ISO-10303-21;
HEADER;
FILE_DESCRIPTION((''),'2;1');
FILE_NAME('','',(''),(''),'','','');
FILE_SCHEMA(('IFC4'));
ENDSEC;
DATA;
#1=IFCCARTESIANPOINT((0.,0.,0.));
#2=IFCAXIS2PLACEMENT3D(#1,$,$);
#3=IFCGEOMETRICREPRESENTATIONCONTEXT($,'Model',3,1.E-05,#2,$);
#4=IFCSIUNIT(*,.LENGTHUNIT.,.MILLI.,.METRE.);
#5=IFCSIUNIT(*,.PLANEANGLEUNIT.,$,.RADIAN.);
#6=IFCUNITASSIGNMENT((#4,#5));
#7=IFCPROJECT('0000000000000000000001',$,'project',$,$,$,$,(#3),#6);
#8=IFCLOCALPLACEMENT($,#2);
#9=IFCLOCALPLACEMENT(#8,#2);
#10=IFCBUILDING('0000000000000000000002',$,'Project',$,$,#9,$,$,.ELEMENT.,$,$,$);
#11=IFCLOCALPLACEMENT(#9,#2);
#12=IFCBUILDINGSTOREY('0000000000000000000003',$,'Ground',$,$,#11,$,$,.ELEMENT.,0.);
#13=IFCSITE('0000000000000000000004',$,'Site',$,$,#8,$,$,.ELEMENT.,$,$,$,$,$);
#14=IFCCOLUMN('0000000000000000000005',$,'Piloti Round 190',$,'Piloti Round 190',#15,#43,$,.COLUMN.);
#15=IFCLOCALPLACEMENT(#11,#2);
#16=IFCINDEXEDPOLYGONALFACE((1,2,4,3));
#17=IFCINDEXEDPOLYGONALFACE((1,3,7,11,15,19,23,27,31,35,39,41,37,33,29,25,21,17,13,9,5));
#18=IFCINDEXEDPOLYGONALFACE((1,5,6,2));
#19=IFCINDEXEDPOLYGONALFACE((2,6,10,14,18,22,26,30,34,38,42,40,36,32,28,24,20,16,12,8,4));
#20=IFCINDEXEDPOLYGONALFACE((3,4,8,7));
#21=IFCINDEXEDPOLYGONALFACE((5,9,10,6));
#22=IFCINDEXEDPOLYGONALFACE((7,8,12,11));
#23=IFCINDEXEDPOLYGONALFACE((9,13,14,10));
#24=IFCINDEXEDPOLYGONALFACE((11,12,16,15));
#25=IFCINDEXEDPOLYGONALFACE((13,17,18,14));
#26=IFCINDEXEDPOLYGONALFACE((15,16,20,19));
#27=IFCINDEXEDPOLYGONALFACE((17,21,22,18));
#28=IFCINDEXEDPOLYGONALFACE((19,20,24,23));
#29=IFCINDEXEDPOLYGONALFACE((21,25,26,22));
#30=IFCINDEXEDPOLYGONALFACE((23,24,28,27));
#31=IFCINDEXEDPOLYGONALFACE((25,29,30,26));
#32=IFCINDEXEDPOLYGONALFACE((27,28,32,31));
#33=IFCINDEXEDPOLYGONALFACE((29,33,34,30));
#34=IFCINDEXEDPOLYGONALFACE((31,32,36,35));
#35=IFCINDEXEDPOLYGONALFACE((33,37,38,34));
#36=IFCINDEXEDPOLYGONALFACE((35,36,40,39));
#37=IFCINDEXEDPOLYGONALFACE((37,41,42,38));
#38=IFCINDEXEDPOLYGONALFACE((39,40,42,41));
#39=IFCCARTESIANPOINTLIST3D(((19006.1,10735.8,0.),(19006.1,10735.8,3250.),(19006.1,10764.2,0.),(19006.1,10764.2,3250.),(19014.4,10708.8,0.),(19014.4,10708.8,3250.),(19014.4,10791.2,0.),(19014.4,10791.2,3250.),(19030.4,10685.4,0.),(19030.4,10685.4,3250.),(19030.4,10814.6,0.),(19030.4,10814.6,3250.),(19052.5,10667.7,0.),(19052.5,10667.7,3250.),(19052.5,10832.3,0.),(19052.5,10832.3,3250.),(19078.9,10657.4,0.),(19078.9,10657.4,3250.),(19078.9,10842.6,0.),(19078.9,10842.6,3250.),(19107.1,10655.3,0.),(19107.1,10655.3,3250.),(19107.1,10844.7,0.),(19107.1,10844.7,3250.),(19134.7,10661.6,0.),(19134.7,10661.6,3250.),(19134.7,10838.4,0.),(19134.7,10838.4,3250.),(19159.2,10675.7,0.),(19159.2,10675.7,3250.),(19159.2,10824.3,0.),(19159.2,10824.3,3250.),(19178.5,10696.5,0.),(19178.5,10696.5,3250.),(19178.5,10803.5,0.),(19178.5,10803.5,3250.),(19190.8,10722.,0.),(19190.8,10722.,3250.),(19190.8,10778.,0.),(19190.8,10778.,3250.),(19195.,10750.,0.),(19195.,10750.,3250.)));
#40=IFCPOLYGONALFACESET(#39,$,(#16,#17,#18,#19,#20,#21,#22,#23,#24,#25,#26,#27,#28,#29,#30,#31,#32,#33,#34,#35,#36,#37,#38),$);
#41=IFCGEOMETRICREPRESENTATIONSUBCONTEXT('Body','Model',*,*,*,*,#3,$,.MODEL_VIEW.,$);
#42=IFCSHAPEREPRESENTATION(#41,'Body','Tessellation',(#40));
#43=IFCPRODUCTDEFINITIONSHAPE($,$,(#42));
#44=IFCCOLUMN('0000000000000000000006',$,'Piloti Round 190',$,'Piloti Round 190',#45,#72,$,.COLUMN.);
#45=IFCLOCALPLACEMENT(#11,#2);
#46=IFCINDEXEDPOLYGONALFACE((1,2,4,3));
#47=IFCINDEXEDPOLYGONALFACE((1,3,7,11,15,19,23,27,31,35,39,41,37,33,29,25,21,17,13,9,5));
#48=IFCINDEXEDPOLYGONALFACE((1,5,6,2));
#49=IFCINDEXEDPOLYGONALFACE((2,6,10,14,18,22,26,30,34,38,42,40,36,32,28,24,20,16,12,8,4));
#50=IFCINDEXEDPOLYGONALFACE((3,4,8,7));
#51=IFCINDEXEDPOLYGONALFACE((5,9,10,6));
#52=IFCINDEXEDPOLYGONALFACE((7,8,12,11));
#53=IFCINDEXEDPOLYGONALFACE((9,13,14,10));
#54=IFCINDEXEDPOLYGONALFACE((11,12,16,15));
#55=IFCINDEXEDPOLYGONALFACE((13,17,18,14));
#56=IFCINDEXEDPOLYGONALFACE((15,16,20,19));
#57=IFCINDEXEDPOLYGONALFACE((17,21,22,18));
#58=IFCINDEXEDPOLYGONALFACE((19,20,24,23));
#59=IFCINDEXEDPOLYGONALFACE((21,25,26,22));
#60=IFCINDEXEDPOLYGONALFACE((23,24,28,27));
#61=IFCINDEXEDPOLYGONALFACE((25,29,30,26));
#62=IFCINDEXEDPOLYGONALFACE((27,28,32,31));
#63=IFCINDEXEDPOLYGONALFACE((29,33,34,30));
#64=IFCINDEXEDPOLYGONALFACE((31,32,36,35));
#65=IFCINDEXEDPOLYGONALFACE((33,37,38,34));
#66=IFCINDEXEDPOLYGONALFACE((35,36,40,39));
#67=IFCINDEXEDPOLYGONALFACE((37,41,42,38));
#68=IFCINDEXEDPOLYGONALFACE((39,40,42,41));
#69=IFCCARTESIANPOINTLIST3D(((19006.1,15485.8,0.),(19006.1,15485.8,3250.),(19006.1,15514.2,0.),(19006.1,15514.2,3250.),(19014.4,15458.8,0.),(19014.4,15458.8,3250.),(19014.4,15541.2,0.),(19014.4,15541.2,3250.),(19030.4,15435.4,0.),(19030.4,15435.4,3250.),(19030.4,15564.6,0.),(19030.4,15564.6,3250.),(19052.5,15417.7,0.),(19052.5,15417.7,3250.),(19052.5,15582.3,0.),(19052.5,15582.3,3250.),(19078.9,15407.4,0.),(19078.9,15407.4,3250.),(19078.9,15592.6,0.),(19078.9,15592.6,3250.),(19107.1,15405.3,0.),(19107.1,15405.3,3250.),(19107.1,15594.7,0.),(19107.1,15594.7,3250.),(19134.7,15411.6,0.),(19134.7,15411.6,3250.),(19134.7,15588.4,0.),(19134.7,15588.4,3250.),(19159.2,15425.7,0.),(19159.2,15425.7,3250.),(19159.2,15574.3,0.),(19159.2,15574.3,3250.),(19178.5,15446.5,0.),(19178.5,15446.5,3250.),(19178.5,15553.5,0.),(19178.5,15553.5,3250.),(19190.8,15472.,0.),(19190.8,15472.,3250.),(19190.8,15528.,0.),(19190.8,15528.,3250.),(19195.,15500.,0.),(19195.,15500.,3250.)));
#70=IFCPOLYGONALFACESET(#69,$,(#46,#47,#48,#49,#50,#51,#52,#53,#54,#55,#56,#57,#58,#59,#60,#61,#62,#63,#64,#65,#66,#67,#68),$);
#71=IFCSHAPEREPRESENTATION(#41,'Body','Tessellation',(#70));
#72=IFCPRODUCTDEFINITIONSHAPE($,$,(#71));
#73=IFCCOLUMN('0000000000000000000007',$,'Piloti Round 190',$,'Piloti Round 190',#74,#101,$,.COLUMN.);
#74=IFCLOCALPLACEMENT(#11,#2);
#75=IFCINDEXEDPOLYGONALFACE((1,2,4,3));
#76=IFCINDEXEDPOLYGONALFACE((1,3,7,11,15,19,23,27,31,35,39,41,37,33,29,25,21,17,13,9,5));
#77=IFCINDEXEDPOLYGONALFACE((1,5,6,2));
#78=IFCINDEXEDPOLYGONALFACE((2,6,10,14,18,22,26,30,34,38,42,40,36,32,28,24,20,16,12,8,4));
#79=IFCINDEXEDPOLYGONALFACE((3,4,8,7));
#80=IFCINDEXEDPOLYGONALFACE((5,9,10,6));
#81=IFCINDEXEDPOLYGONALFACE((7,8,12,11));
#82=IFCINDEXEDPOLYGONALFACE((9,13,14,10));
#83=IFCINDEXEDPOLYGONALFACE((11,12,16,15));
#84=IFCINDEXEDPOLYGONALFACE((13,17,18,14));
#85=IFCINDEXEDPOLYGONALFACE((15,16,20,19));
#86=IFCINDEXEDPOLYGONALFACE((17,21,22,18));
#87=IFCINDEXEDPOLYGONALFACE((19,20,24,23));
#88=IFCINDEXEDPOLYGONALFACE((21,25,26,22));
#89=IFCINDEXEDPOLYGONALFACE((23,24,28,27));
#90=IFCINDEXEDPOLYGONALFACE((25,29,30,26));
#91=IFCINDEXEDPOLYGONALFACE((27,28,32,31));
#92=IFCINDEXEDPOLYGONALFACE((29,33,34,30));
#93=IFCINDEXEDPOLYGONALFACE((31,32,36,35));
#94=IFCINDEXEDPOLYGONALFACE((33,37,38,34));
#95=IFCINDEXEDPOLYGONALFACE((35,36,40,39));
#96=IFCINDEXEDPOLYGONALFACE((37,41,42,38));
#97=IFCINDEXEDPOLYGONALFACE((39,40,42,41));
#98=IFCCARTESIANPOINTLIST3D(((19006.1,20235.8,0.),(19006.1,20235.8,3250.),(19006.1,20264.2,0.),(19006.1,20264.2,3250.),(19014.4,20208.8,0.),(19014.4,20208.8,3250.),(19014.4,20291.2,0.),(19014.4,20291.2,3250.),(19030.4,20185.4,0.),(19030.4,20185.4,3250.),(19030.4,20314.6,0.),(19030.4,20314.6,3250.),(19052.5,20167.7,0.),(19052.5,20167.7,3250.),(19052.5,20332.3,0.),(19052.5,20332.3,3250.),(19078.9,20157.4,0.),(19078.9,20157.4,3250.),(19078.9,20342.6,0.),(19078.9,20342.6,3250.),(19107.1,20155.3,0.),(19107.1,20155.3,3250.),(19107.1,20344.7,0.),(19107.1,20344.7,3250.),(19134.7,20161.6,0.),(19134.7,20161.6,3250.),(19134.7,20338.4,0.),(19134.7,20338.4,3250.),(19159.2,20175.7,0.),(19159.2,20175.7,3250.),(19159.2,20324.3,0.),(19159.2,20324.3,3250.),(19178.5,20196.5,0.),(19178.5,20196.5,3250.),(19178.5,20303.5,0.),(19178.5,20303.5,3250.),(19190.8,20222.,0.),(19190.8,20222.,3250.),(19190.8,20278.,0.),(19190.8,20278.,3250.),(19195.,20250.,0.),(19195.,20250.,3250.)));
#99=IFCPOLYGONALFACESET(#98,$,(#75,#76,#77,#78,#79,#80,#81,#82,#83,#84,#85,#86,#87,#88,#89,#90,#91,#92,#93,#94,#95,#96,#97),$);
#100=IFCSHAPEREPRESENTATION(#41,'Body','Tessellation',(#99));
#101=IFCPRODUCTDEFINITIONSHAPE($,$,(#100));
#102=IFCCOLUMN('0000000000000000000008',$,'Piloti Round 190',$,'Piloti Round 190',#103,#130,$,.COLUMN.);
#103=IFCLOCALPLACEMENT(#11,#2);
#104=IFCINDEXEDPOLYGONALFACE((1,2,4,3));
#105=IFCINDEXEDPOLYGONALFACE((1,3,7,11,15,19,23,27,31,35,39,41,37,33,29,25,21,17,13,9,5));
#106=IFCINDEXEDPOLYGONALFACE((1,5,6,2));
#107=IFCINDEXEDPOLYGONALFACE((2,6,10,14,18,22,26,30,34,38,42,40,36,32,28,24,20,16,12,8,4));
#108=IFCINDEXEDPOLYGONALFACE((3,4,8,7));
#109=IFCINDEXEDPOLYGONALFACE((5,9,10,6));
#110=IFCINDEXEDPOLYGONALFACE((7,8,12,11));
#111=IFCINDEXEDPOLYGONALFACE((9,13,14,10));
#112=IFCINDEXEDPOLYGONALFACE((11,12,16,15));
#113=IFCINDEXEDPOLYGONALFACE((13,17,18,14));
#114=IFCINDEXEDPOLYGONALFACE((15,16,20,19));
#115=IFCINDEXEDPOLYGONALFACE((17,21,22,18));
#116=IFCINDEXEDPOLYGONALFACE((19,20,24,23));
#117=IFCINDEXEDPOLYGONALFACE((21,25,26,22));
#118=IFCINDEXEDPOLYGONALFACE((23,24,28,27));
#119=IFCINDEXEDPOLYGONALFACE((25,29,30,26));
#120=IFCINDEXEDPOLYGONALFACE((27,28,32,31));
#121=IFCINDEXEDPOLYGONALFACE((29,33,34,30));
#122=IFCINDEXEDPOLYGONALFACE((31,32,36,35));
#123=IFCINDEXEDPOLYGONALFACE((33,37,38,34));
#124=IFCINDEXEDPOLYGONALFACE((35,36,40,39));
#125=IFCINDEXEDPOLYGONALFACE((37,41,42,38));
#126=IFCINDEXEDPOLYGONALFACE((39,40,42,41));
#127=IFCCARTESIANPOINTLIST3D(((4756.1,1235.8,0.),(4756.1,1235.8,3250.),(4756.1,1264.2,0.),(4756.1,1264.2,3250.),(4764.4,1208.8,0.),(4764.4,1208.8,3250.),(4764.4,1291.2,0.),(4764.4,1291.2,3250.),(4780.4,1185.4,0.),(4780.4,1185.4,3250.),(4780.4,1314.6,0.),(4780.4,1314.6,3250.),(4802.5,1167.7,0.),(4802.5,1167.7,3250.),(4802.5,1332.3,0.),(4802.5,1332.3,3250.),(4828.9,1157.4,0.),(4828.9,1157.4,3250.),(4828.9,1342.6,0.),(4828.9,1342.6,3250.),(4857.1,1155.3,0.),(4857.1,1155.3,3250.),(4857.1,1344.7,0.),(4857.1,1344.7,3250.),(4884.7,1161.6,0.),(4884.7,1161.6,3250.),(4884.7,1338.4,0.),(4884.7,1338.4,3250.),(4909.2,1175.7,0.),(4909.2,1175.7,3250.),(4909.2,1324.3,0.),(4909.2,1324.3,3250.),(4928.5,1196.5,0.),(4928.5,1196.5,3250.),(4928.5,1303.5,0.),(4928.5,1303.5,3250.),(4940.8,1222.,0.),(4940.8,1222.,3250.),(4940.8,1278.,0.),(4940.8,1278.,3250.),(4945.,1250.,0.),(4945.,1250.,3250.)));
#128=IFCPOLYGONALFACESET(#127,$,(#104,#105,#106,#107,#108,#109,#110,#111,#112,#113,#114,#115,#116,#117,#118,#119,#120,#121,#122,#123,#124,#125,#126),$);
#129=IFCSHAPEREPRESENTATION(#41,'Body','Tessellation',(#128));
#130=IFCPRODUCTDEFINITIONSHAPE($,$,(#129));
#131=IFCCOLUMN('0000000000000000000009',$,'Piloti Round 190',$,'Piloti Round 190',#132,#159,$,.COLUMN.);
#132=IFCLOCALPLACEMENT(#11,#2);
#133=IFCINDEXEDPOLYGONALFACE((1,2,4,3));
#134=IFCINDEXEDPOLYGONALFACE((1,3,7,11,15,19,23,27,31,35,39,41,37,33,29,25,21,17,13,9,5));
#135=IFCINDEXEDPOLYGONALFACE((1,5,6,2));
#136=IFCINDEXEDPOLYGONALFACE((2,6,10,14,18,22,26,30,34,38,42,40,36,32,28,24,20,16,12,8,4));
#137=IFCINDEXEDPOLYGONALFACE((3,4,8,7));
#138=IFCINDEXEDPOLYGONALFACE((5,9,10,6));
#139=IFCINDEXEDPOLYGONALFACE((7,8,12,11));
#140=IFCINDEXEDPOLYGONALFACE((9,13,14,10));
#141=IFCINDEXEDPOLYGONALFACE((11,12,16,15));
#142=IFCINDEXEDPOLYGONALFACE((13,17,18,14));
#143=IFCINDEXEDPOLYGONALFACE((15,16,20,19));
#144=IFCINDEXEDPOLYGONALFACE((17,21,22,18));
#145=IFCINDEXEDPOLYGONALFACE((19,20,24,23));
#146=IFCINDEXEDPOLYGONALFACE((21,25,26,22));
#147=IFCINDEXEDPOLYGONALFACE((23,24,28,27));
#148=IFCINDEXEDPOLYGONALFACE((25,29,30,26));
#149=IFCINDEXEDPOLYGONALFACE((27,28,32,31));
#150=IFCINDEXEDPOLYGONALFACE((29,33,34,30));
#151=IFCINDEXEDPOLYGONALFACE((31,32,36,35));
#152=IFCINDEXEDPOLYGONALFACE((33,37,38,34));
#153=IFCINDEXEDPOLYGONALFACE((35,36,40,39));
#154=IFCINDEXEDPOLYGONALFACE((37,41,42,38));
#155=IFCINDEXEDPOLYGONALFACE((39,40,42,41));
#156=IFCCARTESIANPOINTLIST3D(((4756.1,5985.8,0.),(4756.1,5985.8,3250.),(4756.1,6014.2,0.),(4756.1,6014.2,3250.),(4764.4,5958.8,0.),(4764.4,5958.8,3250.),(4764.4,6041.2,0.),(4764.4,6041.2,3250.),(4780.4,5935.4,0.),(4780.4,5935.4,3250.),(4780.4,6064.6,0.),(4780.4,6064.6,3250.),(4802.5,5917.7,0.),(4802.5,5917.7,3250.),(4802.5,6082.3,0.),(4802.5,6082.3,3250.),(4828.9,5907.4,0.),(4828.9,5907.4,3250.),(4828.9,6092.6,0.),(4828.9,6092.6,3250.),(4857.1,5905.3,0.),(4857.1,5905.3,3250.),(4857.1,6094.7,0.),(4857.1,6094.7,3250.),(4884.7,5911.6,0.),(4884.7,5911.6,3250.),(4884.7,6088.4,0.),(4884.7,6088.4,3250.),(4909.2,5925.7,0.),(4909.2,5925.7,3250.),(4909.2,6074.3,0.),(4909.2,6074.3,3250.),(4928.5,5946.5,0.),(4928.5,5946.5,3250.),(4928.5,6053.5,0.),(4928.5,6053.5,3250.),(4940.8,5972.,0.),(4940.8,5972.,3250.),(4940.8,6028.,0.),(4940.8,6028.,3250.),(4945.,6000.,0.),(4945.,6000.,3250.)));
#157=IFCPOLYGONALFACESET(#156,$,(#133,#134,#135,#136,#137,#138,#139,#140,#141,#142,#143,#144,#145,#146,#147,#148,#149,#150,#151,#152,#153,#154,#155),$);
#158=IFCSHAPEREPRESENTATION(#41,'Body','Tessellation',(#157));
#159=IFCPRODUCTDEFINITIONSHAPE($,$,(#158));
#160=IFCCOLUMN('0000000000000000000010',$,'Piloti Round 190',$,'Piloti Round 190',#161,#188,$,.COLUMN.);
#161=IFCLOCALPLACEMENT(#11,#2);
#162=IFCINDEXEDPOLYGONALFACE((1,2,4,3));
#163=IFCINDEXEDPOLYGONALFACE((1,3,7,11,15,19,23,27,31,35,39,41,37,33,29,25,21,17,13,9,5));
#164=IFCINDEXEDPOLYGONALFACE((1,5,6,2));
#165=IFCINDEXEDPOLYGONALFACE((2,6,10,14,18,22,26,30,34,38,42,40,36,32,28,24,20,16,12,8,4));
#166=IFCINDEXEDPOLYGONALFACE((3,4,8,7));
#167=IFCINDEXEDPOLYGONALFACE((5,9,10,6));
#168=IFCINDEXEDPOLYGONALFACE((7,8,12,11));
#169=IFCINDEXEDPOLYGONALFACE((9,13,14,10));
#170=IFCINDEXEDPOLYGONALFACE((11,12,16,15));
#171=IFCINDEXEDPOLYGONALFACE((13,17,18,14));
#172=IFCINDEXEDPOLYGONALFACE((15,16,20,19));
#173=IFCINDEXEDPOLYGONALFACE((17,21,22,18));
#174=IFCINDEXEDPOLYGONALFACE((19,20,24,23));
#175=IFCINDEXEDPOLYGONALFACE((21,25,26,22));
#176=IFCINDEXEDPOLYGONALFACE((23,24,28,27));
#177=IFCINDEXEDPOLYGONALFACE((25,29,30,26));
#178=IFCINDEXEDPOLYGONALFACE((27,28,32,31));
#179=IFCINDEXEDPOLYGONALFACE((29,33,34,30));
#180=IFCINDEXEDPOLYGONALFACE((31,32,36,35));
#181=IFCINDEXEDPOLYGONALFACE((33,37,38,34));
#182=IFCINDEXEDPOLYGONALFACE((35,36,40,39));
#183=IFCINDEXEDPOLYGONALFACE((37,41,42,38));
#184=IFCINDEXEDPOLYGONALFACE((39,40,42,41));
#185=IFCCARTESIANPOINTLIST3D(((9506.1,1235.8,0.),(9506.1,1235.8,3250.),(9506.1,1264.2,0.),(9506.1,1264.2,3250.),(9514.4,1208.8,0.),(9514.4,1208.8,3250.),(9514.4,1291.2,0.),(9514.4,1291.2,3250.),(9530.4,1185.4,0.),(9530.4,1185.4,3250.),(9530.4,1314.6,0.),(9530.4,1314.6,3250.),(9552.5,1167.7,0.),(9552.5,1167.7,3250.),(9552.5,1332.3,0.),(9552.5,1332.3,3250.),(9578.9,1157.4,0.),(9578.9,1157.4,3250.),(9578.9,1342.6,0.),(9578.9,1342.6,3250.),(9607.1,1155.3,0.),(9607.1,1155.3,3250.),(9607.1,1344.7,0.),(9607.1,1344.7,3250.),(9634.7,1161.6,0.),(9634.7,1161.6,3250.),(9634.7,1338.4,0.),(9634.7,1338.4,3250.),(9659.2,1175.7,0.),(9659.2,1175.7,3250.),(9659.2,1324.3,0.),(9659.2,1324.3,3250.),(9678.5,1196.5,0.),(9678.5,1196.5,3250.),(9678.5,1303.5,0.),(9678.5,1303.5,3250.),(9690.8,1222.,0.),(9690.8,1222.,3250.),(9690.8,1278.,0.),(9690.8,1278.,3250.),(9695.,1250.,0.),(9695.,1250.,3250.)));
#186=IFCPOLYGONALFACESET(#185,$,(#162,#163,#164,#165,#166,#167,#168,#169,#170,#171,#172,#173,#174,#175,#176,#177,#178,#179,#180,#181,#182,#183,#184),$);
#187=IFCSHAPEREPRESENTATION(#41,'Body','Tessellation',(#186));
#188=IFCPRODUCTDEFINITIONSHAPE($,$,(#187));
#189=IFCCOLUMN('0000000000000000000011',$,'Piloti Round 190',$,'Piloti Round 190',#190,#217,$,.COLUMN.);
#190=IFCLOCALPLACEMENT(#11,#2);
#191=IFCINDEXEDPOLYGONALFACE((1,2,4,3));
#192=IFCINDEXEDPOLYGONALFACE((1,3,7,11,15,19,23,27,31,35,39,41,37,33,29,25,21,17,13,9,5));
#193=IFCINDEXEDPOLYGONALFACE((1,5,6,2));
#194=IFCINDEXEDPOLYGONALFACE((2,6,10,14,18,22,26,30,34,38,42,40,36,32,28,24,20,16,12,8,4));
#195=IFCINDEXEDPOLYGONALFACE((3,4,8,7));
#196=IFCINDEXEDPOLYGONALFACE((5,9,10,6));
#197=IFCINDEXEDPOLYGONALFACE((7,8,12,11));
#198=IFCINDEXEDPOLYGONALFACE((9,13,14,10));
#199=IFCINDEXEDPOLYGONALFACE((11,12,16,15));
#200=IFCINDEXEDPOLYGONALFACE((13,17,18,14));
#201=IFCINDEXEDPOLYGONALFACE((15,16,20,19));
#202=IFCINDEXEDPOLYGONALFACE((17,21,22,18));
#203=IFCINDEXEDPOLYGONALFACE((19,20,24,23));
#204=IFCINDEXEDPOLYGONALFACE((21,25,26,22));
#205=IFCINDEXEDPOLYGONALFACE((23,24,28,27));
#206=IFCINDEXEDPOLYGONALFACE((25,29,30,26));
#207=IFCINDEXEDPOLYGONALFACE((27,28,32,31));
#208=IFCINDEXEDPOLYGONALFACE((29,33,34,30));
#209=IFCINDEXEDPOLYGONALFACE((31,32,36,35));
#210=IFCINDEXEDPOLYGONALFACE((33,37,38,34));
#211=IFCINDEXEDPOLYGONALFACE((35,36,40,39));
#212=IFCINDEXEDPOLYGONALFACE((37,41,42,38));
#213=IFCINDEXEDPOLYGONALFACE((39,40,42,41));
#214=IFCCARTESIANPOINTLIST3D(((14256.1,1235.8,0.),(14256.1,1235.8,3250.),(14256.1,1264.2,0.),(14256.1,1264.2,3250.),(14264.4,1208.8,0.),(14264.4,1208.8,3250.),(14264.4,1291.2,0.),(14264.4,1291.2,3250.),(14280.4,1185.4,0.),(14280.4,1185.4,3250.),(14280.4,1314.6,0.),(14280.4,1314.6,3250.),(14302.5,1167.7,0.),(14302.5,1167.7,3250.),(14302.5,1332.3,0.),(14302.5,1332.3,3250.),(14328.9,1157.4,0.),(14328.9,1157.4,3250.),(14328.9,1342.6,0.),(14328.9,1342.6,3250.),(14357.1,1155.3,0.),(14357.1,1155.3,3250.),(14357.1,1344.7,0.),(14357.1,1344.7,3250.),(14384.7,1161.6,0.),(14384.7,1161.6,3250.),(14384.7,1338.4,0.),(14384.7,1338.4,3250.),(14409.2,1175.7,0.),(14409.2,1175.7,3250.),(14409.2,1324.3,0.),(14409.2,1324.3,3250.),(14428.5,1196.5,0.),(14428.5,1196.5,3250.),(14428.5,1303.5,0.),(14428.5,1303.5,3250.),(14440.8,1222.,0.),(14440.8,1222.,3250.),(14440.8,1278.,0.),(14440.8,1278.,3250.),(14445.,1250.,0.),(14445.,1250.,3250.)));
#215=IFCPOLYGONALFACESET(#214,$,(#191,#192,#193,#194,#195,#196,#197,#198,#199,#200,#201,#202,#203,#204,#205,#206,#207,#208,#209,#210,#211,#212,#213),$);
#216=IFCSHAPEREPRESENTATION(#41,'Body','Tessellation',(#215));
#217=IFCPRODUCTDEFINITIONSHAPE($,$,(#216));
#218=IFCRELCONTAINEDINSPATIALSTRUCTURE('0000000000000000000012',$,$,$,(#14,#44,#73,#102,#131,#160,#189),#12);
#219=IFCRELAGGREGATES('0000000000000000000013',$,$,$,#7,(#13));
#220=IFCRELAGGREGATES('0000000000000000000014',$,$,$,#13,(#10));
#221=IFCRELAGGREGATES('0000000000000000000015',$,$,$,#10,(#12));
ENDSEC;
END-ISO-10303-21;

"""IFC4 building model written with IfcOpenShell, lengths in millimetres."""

from ifc_helpers import new_model, si_unit, frame, origin, origin_2d, place, context, subcontext, project, spatial, circle, extrude, element, save


model = new_model("IFC4")

# Units and contexts
model_context = context("Model", 3, precision=1e-05, world=origin())
body_context = subcontext(model_context, "Body", "Model", "MODEL_VIEW")
ifc_project = project(units=[si_unit("LENGTHUNIT", "METRE", prefix="MILLI"), si_unit("PLANEANGLEUNIT", "RADIAN")], contexts=[model_context])

# Site, building, storey
site_placement = place(None, origin())
site = spatial("IfcSite", under=ifc_project, at=site_placement, Name="Site", CompositionType="ELEMENT")
building_placement = place(site_placement, origin())
building = spatial("IfcBuilding", under=site, at=building_placement, Name="Project", CompositionType="ELEMENT")
storey_placement = place(building_placement, origin())
storey = spatial("IfcBuildingStorey", under=building, at=storey_placement, Name="Ground", CompositionType="ELEMENT", Elevation=0.0)

# Columns
for number, where, z_axis, x_axis, name in (
    (1, (19100.0, 10750.0, 0.0), (0.0, 0.0, 1.0), (1.0, 0.0, 0.0), "Piloti Round 190"),
    (2, (19100.0, 15500.0, 0.0), (0.0, 0.0, 1.0), (1.0, 0.0, 0.0), "Piloti Round 190"),
    (3, (19100.0, 20250.0, 0.0), (0.0, 0.0, 1.0), (1.0, 0.0, 0.0), "Piloti Round 190"),
    (4, (4850.0, 1250.0, 0.0), (0.0, 0.0, 1.0), (1.0, 0.0, 0.0), "Piloti Round 190"),
    (5, (4850.0, 6000.0, 0.0), (0.0, 0.0, 1.0), (1.0, 0.0, 0.0), "Piloti Round 190"),
    (6, (9600.0, 1250.0, 0.0), (0.0, 0.0, 1.0), (1.0, 0.0, 0.0), "Piloti Round 190"),
    (7, (14350.0, 1250.0, 0.0), (0.0, 0.0, 1.0), (1.0, 0.0, 0.0), "Piloti Round 190"),
):
    element("IfcColumn", number, at=place(storey_placement, frame(where, z_axis=z_axis, x_axis=x_axis)), inside=storey, Name=name, ObjectType="Piloti Round 190", PredefinedType="COLUMN", context=body_context, shape_type="SweptSolid", body=[
        extrude(circle(Radius=95.0, at=origin_2d()), origin(), (0.0, 0.0, 1.0), 3250.0),
    ])

save(model, "model.ifc")
